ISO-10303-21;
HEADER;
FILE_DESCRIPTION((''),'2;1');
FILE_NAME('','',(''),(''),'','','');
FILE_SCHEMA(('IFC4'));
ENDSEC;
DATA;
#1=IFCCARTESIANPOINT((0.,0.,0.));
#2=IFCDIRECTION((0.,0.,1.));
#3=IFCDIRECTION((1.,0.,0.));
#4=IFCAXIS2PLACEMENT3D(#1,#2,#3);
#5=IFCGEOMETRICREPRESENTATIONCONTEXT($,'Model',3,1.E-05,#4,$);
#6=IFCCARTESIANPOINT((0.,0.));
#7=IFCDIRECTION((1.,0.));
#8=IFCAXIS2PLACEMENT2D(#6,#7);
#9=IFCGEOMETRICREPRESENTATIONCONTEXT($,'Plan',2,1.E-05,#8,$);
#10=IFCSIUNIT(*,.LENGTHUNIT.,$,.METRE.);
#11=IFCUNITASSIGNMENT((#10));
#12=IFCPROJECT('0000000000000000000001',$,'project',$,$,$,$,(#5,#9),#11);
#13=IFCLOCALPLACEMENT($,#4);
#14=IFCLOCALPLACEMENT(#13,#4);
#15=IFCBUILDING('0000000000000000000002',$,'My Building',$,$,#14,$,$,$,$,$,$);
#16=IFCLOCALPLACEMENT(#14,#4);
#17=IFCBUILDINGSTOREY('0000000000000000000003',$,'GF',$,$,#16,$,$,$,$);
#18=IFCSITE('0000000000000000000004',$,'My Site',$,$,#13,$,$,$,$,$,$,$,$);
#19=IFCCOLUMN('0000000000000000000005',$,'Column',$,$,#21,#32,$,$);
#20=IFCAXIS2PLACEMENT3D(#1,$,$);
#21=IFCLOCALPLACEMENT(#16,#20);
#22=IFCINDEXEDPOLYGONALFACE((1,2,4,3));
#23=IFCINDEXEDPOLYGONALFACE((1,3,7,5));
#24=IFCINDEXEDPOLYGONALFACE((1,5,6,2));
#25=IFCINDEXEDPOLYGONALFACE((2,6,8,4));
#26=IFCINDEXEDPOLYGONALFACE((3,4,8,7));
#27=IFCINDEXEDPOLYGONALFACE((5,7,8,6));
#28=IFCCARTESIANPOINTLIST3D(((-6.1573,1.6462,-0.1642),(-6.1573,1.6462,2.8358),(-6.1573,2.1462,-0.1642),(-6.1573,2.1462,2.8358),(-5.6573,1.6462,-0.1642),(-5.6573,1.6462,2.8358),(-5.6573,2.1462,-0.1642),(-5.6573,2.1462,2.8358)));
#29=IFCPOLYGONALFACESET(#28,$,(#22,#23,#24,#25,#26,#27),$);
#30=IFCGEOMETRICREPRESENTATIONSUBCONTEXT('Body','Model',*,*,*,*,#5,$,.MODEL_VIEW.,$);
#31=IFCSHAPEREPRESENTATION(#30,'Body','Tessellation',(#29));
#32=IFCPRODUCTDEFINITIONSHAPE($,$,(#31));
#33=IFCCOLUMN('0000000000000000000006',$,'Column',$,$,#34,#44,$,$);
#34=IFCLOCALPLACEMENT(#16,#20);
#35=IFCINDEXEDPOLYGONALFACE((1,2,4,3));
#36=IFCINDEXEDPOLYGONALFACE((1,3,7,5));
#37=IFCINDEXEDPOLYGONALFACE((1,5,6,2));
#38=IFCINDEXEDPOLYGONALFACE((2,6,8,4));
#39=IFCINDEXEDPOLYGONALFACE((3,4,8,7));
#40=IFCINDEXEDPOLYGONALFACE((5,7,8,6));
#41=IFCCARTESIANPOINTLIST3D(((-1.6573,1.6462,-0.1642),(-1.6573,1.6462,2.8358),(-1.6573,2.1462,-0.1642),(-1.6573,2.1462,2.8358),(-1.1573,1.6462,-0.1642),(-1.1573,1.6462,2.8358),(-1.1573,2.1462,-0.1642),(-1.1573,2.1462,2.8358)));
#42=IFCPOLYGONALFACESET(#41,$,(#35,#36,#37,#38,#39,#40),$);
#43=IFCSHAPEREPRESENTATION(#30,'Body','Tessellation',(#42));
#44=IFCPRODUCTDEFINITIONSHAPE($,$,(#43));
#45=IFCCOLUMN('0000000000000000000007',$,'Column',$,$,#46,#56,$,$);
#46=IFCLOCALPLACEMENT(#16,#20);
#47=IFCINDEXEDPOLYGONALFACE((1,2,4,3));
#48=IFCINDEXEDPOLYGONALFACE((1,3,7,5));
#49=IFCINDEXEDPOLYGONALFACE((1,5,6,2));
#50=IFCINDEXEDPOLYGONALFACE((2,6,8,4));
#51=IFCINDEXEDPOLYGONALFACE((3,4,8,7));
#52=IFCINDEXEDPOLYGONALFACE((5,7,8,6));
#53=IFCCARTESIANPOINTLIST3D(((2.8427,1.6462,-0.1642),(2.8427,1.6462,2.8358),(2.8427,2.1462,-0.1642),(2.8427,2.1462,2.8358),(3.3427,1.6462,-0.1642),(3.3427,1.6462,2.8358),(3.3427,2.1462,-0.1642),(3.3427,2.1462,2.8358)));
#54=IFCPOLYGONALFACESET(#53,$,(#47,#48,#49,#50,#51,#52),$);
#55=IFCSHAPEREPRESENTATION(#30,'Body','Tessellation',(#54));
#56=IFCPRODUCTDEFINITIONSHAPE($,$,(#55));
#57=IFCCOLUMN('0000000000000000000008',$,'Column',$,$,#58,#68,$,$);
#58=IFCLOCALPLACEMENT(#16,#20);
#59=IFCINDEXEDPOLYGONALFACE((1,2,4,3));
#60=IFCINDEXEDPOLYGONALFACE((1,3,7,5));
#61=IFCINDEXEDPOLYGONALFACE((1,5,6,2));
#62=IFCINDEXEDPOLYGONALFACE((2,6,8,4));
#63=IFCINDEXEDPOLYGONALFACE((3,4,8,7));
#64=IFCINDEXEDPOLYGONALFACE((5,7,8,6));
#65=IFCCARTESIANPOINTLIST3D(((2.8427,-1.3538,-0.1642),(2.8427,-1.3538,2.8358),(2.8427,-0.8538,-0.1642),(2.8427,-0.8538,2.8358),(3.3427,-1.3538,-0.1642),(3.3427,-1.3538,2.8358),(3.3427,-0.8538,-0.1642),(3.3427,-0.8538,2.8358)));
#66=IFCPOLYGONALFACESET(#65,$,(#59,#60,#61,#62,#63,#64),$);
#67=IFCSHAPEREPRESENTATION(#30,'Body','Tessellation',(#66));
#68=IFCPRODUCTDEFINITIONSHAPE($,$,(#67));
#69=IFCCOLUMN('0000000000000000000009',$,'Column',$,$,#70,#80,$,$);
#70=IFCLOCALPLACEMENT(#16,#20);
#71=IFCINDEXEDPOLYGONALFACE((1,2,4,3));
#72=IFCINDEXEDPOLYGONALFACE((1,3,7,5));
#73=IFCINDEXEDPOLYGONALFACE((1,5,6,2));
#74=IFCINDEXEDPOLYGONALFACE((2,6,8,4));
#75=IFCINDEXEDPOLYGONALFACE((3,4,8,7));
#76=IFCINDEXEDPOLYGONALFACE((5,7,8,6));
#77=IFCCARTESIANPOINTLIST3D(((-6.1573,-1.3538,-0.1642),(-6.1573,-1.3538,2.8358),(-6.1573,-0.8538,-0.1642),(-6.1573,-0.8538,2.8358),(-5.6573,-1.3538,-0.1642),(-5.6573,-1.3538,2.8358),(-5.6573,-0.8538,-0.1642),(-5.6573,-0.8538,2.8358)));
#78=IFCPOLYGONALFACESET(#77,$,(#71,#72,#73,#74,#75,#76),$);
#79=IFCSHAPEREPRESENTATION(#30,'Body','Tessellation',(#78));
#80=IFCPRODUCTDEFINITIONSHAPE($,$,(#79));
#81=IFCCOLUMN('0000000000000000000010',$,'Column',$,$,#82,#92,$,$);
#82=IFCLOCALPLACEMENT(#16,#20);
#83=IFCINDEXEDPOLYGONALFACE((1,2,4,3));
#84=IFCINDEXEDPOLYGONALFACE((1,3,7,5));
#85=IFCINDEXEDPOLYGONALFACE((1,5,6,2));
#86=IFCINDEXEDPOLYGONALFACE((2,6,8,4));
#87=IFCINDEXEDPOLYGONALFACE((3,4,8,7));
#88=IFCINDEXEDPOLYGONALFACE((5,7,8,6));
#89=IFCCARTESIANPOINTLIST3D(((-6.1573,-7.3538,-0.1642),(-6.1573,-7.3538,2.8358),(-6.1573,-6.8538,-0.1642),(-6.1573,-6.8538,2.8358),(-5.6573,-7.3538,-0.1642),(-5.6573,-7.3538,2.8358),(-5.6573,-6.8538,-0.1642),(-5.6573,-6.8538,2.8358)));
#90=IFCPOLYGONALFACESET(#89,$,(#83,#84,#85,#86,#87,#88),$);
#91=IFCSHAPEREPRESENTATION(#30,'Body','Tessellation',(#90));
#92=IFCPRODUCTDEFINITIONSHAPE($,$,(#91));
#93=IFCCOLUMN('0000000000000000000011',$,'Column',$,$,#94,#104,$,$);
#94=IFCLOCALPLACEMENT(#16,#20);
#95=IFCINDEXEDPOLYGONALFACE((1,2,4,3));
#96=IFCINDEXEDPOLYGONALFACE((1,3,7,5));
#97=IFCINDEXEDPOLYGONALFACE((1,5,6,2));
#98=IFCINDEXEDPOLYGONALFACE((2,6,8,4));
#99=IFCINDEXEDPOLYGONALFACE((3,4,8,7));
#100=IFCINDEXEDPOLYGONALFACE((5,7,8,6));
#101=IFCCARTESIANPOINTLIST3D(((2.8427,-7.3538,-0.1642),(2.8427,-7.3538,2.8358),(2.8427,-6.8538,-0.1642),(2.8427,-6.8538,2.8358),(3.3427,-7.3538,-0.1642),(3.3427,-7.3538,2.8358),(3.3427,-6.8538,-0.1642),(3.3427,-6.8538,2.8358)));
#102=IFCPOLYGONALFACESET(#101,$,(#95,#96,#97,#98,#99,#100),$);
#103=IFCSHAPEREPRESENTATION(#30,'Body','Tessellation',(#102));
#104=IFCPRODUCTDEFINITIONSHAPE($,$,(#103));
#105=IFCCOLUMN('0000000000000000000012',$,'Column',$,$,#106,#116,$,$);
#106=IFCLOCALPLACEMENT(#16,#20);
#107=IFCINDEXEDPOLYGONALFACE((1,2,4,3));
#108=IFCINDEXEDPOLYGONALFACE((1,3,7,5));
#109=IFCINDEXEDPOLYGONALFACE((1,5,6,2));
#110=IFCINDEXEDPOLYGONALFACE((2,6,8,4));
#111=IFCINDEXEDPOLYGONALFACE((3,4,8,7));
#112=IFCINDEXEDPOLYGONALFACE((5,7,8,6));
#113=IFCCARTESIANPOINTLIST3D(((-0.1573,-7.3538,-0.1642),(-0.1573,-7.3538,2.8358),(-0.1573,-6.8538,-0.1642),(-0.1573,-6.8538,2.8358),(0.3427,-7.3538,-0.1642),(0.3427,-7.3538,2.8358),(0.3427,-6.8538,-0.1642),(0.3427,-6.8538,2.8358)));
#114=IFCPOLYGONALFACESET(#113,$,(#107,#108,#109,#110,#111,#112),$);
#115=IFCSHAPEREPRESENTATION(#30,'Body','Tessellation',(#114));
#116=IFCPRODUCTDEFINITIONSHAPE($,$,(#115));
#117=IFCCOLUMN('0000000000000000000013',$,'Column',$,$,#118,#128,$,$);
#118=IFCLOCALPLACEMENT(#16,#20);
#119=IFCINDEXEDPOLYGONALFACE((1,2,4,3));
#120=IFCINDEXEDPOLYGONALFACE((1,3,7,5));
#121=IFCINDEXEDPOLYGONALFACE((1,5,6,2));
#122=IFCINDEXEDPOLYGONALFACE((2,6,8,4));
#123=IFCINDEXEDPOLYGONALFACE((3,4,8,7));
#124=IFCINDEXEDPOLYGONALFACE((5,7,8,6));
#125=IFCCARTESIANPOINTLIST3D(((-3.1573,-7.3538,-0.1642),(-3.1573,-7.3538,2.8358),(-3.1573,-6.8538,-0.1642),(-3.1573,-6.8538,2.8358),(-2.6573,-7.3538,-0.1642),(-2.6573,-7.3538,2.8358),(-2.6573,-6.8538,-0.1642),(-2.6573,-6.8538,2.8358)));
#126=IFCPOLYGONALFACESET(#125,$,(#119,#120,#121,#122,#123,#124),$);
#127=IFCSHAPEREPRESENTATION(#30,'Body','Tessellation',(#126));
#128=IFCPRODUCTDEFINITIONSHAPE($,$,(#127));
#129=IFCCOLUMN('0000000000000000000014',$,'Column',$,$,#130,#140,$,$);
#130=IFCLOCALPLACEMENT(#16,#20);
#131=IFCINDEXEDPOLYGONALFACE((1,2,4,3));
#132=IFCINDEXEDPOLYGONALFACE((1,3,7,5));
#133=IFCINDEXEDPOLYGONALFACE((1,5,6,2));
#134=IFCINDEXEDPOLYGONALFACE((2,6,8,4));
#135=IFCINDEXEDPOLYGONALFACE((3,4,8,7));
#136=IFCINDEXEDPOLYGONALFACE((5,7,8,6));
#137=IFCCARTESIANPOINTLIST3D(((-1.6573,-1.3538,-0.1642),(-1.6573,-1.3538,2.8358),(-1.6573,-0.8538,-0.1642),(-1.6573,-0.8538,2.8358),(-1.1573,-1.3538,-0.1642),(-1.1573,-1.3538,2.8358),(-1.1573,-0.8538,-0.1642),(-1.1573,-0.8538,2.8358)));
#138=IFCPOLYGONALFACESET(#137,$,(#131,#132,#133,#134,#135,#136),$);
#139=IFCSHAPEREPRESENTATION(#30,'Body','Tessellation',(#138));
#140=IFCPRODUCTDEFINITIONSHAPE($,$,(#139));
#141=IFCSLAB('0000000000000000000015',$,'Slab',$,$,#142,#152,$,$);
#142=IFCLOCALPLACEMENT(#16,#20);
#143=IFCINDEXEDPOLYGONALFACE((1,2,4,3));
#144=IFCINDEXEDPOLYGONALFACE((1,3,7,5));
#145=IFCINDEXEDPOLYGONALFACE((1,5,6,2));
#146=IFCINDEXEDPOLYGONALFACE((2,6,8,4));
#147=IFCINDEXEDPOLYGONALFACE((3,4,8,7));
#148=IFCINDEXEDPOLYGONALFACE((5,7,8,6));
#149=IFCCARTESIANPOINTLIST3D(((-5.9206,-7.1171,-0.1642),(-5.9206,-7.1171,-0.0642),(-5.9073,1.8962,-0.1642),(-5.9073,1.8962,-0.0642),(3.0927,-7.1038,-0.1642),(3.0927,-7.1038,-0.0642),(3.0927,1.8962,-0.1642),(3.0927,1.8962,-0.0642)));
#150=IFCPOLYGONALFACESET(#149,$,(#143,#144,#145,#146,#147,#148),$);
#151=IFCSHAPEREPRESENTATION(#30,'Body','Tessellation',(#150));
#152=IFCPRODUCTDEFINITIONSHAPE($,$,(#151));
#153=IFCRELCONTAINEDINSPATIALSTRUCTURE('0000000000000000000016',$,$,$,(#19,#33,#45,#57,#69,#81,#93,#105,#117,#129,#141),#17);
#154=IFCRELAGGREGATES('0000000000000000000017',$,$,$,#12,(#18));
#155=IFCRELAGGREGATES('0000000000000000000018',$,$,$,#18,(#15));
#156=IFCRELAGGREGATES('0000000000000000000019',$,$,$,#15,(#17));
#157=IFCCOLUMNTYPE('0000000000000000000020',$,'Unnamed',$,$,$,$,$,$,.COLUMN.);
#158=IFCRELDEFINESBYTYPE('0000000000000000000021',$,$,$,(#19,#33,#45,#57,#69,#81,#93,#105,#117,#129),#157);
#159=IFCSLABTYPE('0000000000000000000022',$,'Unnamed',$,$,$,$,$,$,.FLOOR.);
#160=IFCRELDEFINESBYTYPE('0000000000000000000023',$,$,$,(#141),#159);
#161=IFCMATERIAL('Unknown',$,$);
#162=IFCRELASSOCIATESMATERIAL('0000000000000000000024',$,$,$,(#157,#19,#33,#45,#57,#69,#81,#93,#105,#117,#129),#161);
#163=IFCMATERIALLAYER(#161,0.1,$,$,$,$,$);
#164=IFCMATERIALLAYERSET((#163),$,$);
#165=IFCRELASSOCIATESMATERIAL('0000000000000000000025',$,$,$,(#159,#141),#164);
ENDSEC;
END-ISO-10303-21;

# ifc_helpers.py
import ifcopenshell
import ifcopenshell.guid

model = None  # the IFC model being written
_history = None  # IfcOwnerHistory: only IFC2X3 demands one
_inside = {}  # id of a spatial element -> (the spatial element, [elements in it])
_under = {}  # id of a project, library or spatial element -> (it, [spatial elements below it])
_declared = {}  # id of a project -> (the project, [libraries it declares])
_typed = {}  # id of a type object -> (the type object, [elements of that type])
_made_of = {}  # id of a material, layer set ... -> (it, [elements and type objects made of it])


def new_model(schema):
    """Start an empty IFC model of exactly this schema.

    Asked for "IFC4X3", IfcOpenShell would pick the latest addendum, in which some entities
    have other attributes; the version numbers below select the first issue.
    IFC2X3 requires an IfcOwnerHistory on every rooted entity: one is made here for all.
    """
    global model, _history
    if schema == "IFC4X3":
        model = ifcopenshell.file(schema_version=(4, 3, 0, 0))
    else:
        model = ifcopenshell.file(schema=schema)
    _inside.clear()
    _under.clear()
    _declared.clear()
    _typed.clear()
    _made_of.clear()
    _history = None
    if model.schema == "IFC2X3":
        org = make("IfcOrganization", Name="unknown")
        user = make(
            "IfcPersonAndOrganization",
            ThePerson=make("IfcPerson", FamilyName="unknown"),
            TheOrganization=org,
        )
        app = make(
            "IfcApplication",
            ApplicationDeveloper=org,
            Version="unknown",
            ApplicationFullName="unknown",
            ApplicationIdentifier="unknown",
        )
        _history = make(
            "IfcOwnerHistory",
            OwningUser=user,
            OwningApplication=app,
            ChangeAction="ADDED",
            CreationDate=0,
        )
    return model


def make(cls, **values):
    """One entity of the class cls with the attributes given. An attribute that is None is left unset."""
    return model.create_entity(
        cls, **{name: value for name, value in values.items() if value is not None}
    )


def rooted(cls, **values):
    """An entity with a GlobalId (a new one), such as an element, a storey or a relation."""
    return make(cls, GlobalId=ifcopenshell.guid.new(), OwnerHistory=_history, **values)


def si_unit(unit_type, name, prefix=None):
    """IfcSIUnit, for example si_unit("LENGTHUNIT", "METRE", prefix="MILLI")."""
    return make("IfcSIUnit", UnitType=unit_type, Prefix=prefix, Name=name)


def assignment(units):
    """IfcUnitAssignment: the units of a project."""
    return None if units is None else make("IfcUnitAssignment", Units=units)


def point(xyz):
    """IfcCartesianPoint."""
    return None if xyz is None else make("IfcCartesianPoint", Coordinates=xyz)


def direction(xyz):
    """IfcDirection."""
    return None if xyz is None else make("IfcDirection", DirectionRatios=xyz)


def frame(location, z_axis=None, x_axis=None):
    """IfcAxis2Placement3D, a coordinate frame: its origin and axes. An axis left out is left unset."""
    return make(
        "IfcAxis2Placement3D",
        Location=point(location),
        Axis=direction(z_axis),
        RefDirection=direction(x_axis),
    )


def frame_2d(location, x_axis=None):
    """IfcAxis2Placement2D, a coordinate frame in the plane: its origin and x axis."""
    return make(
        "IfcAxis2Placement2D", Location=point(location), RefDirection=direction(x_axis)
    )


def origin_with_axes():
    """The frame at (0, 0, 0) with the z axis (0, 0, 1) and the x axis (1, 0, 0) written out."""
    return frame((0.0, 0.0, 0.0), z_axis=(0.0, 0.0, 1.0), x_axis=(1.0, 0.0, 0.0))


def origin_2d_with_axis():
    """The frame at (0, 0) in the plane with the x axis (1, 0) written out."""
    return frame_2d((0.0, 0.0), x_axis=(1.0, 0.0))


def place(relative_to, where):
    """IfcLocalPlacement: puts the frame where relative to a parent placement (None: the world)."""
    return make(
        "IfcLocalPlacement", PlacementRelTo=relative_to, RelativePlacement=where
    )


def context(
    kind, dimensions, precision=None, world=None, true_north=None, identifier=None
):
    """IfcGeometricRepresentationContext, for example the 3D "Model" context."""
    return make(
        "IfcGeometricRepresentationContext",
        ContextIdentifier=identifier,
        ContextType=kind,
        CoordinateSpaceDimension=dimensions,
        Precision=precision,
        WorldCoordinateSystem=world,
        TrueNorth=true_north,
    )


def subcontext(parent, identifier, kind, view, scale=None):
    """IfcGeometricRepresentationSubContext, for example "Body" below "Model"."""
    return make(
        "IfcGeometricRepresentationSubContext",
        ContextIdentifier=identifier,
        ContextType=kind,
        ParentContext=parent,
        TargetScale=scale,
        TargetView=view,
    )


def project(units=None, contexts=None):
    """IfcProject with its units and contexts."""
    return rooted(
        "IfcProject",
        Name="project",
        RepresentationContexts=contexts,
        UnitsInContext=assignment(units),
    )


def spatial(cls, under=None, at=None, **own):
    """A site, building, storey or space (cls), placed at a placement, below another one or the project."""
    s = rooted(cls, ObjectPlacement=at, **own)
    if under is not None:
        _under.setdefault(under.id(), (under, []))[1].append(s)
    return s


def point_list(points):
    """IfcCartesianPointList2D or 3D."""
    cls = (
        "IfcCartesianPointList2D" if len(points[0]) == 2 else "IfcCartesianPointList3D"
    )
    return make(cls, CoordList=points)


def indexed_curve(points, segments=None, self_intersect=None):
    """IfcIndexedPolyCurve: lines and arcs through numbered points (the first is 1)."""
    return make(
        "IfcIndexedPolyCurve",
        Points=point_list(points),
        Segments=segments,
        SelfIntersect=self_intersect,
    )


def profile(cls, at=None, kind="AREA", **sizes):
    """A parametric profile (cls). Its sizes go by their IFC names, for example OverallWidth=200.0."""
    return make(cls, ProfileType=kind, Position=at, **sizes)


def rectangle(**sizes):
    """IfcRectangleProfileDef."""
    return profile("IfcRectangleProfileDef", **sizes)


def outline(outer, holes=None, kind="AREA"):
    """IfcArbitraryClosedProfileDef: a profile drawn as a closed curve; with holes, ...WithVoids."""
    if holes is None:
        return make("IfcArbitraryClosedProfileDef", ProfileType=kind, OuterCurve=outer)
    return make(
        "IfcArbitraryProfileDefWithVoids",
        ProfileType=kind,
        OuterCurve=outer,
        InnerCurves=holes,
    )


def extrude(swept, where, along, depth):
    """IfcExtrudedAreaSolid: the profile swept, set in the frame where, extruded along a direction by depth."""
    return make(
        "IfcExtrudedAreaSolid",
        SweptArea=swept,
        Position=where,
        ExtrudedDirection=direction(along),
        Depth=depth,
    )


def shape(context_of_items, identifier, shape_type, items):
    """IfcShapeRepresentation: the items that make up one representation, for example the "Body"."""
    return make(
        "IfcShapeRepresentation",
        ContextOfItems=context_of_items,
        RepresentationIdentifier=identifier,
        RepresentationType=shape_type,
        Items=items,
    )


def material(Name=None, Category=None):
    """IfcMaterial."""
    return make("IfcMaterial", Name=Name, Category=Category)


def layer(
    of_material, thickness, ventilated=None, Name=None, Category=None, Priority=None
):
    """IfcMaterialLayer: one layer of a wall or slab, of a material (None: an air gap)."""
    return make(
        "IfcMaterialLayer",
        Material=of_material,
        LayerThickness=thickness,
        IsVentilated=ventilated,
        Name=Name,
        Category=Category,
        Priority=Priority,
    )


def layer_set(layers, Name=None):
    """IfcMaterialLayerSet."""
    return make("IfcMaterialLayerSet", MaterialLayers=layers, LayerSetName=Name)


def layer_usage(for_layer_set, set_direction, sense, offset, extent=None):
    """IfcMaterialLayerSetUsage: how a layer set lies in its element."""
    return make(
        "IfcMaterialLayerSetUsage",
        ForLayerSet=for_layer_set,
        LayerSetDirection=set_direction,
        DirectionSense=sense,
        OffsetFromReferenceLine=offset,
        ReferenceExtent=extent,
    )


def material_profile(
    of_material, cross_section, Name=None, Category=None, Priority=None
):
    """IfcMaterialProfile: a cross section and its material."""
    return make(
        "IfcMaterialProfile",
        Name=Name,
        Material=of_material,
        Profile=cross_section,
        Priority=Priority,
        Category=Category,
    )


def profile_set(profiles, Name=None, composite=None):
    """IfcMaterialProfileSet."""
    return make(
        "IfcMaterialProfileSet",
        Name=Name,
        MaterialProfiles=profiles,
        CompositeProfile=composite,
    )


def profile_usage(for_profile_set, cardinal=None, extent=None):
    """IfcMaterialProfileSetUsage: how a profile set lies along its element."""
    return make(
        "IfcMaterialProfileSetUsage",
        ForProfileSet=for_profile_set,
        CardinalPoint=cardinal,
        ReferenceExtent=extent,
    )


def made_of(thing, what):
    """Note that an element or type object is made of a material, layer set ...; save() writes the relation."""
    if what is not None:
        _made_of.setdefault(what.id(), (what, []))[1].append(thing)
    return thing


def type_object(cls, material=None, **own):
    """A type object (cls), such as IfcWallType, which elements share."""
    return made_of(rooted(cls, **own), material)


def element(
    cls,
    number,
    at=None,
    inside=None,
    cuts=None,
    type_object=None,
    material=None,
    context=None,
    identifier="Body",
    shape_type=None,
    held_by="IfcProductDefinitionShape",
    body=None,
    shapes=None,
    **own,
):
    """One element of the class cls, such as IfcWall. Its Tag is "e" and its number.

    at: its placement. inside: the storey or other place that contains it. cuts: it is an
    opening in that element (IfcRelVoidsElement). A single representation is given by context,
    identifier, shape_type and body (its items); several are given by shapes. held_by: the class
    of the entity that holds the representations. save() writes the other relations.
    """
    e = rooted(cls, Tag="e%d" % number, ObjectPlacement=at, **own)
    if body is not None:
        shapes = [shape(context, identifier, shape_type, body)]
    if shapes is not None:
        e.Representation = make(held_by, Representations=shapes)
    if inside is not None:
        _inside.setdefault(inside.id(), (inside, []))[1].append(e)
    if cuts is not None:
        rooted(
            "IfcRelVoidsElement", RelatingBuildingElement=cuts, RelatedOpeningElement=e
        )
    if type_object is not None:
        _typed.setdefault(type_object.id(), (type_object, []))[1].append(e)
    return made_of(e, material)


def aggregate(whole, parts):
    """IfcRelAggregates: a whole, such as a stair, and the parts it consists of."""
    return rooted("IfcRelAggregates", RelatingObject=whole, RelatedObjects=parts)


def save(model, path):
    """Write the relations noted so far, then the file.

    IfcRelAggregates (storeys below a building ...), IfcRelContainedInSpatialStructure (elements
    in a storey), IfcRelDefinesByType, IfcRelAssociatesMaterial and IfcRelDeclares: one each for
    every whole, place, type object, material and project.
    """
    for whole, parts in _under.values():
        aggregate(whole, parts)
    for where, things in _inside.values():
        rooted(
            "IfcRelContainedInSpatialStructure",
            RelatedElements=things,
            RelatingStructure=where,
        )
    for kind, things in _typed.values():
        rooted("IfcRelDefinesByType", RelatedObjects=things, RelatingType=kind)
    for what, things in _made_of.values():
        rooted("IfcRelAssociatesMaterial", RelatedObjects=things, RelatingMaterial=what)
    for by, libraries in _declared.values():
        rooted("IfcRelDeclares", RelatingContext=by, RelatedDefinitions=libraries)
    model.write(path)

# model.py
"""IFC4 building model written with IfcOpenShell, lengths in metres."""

from ifc_helpers import new_model, si_unit, frame, origin_with_axes, origin_2d_with_axis, place, context, subcontext, project, spatial, indexed_curve, rectangle, outline, extrude, material, layer, layer_set, layer_usage, material_profile, profile_set, profile_usage, type_object, element, save


model = new_model("IFC4")

# Units and contexts
model_context = context("Model", 3, precision=1e-05, world=origin_with_axes())
plan_context = context("Plan", 2, precision=1e-05, world=origin_2d_with_axis())
body_context_1 = subcontext(model_context, "Body", "Model", "MODEL_VIEW")
ifc_project = project(units=[si_unit("LENGTHUNIT", "METRE")], contexts=[model_context, plan_context])

# Site, building, storey
site_placement = place(None, origin_with_axes())
site = spatial("IfcSite", under=ifc_project, at=site_placement, Name="My Site")
building_placement = place(site_placement, origin_with_axes())
building = spatial("IfcBuilding", under=site, at=building_placement, Name="My Building")
storey_placement = place(building_placement, origin_with_axes())
storey = spatial("IfcBuildingStorey", under=building, at=storey_placement, Name="GF")

# Columns
ifc_material = material(Name="Unknown")
ifc_material_profile = material_profile(ifc_material, rectangle(XDim=0.5, YDim=0.5))
ifc_profile_set = profile_set([ifc_material_profile])
ifc_profile_usage_1 = profile_usage(ifc_profile_set, cardinal=5)
column_type = type_object("IfcColumnType", Name="Unnamed", PredefinedType="COLUMN", material=ifc_profile_set)
column_1_placement = place(storey_placement, frame((-5.9073, 1.8962, -0.1642), z_axis=(0.0, 0.0, 1.0), x_axis=(1.0, 0.0, 0.0)))
element("IfcColumn", 1, at=column_1_placement, inside=storey, type_object=column_type, material=ifc_profile_usage_1, Name="Column", context=body_context_1, shape_type="SweptSolid", body=[
    extrude(rectangle(XDim=0.5, YDim=0.5), origin_with_axes(), (0.0, 0.0, 1.0), 3.0),
])
ifc_profile_usage_2 = profile_usage(ifc_profile_set, cardinal=5)
column_2_placement = place(storey_placement, frame((-1.4073, 1.8962, -0.1642), z_axis=(0.0, 0.0, 1.0), x_axis=(1.0, 0.0, 0.0)))
element("IfcColumn", 2, at=column_2_placement, inside=storey, type_object=column_type, material=ifc_profile_usage_2, Name="Column", context=body_context_1, shape_type="SweptSolid", body=[
    extrude(rectangle(XDim=0.5, YDim=0.5), origin_with_axes(), (0.0, 0.0, 1.0), 3.0),
])
ifc_profile_usage_3 = profile_usage(ifc_profile_set, cardinal=5)
column_3_placement = place(storey_placement, frame((3.0927, 1.8962, -0.1642), z_axis=(0.0, 0.0, 1.0), x_axis=(1.0, 0.0, 0.0)))
element("IfcColumn", 3, at=column_3_placement, inside=storey, type_object=column_type, material=ifc_profile_usage_3, Name="Column", context=body_context_1, shape_type="SweptSolid", body=[
    extrude(rectangle(XDim=0.5, YDim=0.5), origin_with_axes(), (0.0, 0.0, 1.0), 3.0),
])
ifc_profile_usage_4 = profile_usage(ifc_profile_set, cardinal=5)
column_4_placement = place(storey_placement, frame((3.0927, -1.1038, -0.1642), z_axis=(0.0, 0.0, 1.0), x_axis=(1.0, 0.0, 0.0)))
element("IfcColumn", 4, at=column_4_placement, inside=storey, type_object=column_type, material=ifc_profile_usage_4, Name="Column", context=body_context_1, shape_type="SweptSolid", body=[
    extrude(rectangle(XDim=0.5, YDim=0.5), origin_with_axes(), (0.0, 0.0, 1.0), 3.0),
])
ifc_profile_usage_5 = profile_usage(ifc_profile_set, cardinal=5)
column_5_placement = place(storey_placement, frame((-5.9073, -1.1038, -0.1642), z_axis=(0.0, 0.0, 1.0), x_axis=(1.0, 0.0, 0.0)))
element("IfcColumn", 5, at=column_5_placement, inside=storey, type_object=column_type, material=ifc_profile_usage_5, Name="Column", context=body_context_1, shape_type="SweptSolid", body=[
    extrude(rectangle(XDim=0.5, YDim=0.5), origin_with_axes(), (0.0, 0.0, 1.0), 3.0),
])
ifc_profile_usage_6 = profile_usage(ifc_profile_set, cardinal=5)
column_6_placement = place(storey_placement, frame((-5.9073, -7.1038, -0.1642), z_axis=(0.0, 0.0, 1.0), x_axis=(1.0, 0.0, 0.0)))
element("IfcColumn", 6, at=column_6_placement, inside=storey, type_object=column_type, material=ifc_profile_usage_6, Name="Column", context=body_context_1, shape_type="SweptSolid", body=[
    extrude(rectangle(XDim=0.5, YDim=0.5), origin_with_axes(), (0.0, 0.0, 1.0), 3.0),
])
ifc_profile_usage_7 = profile_usage(ifc_profile_set, cardinal=5)
column_7_placement = place(storey_placement, frame((3.0927, -7.1038, -0.1642), z_axis=(0.0, 0.0, 1.0), x_axis=(1.0, 0.0, 0.0)))
element("IfcColumn", 7, at=column_7_placement, inside=storey, type_object=column_type, material=ifc_profile_usage_7, Name="Column", context=body_context_1, shape_type="SweptSolid", body=[
    extrude(rectangle(XDim=0.5, YDim=0.5), origin_with_axes(), (0.0, 0.0, 1.0), 3.0),
])
ifc_profile_usage_8 = profile_usage(ifc_profile_set, cardinal=5)
column_8_placement = place(storey_placement, frame((0.0927, -7.1038, -0.1642), z_axis=(0.0, 0.0, 1.0), x_axis=(1.0, 0.0, 0.0)))
element("IfcColumn", 8, at=column_8_placement, inside=storey, type_object=column_type, material=ifc_profile_usage_8, Name="Column", context=body_context_1, shape_type="SweptSolid", body=[
    extrude(rectangle(XDim=0.5, YDim=0.5), origin_with_axes(), (0.0, 0.0, 1.0), 3.0),
])
ifc_profile_usage_9 = profile_usage(ifc_profile_set, cardinal=5)
column_9_placement = place(storey_placement, frame((-2.9073, -7.1038, -0.1642), z_axis=(0.0, 0.0, 1.0), x_axis=(1.0, 0.0, 0.0)))
element("IfcColumn", 9, at=column_9_placement, inside=storey, type_object=column_type, material=ifc_profile_usage_9, Name="Column", context=body_context_1, shape_type="SweptSolid", body=[
    extrude(rectangle(XDim=0.5, YDim=0.5), origin_with_axes(), (0.0, 0.0, 1.0), 3.0),
])
ifc_profile_usage_10 = profile_usage(ifc_profile_set, cardinal=5)
column_10_placement = place(storey_placement, frame((-1.4073, -1.1038, -0.1642), z_axis=(0.0, 0.0, 1.0), x_axis=(1.0, 0.0, 0.0)))
element("IfcColumn", 10, at=column_10_placement, inside=storey, type_object=column_type, material=ifc_profile_usage_10, Name="Column", context=body_context_1, shape_type="SweptSolid", body=[
    extrude(rectangle(XDim=0.5, YDim=0.5), origin_with_axes(), (0.0, 0.0, 1.0), 3.0),
])

# Slab
ifc_layer_1 = layer(ifc_material, 0.1)
ifc_layer_set_1 = layer_set([ifc_layer_1])
ifc_layer_usage_1 = layer_usage(ifc_layer_set_1, "AXIS3", "POSITIVE", -0.1)
slab_type = type_object("IfcSlabType", Name="Unnamed", PredefinedType="FLOOR", material=ifc_layer_set_1)
slab_placement = place(storey_placement, frame((-5.9073, 1.8962, -0.0642), z_axis=(0.0, 0.0, 1.0), x_axis=(1.0, 0.0, 0.0)))
element("IfcSlab", 11, at=slab_placement, inside=storey, type_object=slab_type, material=ifc_layer_usage_1, Name="Slab", context=body_context_1, shape_type="SweptSolid", body=[
    extrude(outline(indexed_curve([(0.0, 0.0), (-0.0133, -9.0133), (9.0, -9.0), (9.0, 0.0), (0.0, 0.0)])), frame((0.0, 0.0, -0.1), z_axis=(0.0, 0.0, 1.0), x_axis=(1.0, 0.0, 0.0)), (0.0, 0.0, 1.0), 0.1),
])

save(model, "model.ifc")
